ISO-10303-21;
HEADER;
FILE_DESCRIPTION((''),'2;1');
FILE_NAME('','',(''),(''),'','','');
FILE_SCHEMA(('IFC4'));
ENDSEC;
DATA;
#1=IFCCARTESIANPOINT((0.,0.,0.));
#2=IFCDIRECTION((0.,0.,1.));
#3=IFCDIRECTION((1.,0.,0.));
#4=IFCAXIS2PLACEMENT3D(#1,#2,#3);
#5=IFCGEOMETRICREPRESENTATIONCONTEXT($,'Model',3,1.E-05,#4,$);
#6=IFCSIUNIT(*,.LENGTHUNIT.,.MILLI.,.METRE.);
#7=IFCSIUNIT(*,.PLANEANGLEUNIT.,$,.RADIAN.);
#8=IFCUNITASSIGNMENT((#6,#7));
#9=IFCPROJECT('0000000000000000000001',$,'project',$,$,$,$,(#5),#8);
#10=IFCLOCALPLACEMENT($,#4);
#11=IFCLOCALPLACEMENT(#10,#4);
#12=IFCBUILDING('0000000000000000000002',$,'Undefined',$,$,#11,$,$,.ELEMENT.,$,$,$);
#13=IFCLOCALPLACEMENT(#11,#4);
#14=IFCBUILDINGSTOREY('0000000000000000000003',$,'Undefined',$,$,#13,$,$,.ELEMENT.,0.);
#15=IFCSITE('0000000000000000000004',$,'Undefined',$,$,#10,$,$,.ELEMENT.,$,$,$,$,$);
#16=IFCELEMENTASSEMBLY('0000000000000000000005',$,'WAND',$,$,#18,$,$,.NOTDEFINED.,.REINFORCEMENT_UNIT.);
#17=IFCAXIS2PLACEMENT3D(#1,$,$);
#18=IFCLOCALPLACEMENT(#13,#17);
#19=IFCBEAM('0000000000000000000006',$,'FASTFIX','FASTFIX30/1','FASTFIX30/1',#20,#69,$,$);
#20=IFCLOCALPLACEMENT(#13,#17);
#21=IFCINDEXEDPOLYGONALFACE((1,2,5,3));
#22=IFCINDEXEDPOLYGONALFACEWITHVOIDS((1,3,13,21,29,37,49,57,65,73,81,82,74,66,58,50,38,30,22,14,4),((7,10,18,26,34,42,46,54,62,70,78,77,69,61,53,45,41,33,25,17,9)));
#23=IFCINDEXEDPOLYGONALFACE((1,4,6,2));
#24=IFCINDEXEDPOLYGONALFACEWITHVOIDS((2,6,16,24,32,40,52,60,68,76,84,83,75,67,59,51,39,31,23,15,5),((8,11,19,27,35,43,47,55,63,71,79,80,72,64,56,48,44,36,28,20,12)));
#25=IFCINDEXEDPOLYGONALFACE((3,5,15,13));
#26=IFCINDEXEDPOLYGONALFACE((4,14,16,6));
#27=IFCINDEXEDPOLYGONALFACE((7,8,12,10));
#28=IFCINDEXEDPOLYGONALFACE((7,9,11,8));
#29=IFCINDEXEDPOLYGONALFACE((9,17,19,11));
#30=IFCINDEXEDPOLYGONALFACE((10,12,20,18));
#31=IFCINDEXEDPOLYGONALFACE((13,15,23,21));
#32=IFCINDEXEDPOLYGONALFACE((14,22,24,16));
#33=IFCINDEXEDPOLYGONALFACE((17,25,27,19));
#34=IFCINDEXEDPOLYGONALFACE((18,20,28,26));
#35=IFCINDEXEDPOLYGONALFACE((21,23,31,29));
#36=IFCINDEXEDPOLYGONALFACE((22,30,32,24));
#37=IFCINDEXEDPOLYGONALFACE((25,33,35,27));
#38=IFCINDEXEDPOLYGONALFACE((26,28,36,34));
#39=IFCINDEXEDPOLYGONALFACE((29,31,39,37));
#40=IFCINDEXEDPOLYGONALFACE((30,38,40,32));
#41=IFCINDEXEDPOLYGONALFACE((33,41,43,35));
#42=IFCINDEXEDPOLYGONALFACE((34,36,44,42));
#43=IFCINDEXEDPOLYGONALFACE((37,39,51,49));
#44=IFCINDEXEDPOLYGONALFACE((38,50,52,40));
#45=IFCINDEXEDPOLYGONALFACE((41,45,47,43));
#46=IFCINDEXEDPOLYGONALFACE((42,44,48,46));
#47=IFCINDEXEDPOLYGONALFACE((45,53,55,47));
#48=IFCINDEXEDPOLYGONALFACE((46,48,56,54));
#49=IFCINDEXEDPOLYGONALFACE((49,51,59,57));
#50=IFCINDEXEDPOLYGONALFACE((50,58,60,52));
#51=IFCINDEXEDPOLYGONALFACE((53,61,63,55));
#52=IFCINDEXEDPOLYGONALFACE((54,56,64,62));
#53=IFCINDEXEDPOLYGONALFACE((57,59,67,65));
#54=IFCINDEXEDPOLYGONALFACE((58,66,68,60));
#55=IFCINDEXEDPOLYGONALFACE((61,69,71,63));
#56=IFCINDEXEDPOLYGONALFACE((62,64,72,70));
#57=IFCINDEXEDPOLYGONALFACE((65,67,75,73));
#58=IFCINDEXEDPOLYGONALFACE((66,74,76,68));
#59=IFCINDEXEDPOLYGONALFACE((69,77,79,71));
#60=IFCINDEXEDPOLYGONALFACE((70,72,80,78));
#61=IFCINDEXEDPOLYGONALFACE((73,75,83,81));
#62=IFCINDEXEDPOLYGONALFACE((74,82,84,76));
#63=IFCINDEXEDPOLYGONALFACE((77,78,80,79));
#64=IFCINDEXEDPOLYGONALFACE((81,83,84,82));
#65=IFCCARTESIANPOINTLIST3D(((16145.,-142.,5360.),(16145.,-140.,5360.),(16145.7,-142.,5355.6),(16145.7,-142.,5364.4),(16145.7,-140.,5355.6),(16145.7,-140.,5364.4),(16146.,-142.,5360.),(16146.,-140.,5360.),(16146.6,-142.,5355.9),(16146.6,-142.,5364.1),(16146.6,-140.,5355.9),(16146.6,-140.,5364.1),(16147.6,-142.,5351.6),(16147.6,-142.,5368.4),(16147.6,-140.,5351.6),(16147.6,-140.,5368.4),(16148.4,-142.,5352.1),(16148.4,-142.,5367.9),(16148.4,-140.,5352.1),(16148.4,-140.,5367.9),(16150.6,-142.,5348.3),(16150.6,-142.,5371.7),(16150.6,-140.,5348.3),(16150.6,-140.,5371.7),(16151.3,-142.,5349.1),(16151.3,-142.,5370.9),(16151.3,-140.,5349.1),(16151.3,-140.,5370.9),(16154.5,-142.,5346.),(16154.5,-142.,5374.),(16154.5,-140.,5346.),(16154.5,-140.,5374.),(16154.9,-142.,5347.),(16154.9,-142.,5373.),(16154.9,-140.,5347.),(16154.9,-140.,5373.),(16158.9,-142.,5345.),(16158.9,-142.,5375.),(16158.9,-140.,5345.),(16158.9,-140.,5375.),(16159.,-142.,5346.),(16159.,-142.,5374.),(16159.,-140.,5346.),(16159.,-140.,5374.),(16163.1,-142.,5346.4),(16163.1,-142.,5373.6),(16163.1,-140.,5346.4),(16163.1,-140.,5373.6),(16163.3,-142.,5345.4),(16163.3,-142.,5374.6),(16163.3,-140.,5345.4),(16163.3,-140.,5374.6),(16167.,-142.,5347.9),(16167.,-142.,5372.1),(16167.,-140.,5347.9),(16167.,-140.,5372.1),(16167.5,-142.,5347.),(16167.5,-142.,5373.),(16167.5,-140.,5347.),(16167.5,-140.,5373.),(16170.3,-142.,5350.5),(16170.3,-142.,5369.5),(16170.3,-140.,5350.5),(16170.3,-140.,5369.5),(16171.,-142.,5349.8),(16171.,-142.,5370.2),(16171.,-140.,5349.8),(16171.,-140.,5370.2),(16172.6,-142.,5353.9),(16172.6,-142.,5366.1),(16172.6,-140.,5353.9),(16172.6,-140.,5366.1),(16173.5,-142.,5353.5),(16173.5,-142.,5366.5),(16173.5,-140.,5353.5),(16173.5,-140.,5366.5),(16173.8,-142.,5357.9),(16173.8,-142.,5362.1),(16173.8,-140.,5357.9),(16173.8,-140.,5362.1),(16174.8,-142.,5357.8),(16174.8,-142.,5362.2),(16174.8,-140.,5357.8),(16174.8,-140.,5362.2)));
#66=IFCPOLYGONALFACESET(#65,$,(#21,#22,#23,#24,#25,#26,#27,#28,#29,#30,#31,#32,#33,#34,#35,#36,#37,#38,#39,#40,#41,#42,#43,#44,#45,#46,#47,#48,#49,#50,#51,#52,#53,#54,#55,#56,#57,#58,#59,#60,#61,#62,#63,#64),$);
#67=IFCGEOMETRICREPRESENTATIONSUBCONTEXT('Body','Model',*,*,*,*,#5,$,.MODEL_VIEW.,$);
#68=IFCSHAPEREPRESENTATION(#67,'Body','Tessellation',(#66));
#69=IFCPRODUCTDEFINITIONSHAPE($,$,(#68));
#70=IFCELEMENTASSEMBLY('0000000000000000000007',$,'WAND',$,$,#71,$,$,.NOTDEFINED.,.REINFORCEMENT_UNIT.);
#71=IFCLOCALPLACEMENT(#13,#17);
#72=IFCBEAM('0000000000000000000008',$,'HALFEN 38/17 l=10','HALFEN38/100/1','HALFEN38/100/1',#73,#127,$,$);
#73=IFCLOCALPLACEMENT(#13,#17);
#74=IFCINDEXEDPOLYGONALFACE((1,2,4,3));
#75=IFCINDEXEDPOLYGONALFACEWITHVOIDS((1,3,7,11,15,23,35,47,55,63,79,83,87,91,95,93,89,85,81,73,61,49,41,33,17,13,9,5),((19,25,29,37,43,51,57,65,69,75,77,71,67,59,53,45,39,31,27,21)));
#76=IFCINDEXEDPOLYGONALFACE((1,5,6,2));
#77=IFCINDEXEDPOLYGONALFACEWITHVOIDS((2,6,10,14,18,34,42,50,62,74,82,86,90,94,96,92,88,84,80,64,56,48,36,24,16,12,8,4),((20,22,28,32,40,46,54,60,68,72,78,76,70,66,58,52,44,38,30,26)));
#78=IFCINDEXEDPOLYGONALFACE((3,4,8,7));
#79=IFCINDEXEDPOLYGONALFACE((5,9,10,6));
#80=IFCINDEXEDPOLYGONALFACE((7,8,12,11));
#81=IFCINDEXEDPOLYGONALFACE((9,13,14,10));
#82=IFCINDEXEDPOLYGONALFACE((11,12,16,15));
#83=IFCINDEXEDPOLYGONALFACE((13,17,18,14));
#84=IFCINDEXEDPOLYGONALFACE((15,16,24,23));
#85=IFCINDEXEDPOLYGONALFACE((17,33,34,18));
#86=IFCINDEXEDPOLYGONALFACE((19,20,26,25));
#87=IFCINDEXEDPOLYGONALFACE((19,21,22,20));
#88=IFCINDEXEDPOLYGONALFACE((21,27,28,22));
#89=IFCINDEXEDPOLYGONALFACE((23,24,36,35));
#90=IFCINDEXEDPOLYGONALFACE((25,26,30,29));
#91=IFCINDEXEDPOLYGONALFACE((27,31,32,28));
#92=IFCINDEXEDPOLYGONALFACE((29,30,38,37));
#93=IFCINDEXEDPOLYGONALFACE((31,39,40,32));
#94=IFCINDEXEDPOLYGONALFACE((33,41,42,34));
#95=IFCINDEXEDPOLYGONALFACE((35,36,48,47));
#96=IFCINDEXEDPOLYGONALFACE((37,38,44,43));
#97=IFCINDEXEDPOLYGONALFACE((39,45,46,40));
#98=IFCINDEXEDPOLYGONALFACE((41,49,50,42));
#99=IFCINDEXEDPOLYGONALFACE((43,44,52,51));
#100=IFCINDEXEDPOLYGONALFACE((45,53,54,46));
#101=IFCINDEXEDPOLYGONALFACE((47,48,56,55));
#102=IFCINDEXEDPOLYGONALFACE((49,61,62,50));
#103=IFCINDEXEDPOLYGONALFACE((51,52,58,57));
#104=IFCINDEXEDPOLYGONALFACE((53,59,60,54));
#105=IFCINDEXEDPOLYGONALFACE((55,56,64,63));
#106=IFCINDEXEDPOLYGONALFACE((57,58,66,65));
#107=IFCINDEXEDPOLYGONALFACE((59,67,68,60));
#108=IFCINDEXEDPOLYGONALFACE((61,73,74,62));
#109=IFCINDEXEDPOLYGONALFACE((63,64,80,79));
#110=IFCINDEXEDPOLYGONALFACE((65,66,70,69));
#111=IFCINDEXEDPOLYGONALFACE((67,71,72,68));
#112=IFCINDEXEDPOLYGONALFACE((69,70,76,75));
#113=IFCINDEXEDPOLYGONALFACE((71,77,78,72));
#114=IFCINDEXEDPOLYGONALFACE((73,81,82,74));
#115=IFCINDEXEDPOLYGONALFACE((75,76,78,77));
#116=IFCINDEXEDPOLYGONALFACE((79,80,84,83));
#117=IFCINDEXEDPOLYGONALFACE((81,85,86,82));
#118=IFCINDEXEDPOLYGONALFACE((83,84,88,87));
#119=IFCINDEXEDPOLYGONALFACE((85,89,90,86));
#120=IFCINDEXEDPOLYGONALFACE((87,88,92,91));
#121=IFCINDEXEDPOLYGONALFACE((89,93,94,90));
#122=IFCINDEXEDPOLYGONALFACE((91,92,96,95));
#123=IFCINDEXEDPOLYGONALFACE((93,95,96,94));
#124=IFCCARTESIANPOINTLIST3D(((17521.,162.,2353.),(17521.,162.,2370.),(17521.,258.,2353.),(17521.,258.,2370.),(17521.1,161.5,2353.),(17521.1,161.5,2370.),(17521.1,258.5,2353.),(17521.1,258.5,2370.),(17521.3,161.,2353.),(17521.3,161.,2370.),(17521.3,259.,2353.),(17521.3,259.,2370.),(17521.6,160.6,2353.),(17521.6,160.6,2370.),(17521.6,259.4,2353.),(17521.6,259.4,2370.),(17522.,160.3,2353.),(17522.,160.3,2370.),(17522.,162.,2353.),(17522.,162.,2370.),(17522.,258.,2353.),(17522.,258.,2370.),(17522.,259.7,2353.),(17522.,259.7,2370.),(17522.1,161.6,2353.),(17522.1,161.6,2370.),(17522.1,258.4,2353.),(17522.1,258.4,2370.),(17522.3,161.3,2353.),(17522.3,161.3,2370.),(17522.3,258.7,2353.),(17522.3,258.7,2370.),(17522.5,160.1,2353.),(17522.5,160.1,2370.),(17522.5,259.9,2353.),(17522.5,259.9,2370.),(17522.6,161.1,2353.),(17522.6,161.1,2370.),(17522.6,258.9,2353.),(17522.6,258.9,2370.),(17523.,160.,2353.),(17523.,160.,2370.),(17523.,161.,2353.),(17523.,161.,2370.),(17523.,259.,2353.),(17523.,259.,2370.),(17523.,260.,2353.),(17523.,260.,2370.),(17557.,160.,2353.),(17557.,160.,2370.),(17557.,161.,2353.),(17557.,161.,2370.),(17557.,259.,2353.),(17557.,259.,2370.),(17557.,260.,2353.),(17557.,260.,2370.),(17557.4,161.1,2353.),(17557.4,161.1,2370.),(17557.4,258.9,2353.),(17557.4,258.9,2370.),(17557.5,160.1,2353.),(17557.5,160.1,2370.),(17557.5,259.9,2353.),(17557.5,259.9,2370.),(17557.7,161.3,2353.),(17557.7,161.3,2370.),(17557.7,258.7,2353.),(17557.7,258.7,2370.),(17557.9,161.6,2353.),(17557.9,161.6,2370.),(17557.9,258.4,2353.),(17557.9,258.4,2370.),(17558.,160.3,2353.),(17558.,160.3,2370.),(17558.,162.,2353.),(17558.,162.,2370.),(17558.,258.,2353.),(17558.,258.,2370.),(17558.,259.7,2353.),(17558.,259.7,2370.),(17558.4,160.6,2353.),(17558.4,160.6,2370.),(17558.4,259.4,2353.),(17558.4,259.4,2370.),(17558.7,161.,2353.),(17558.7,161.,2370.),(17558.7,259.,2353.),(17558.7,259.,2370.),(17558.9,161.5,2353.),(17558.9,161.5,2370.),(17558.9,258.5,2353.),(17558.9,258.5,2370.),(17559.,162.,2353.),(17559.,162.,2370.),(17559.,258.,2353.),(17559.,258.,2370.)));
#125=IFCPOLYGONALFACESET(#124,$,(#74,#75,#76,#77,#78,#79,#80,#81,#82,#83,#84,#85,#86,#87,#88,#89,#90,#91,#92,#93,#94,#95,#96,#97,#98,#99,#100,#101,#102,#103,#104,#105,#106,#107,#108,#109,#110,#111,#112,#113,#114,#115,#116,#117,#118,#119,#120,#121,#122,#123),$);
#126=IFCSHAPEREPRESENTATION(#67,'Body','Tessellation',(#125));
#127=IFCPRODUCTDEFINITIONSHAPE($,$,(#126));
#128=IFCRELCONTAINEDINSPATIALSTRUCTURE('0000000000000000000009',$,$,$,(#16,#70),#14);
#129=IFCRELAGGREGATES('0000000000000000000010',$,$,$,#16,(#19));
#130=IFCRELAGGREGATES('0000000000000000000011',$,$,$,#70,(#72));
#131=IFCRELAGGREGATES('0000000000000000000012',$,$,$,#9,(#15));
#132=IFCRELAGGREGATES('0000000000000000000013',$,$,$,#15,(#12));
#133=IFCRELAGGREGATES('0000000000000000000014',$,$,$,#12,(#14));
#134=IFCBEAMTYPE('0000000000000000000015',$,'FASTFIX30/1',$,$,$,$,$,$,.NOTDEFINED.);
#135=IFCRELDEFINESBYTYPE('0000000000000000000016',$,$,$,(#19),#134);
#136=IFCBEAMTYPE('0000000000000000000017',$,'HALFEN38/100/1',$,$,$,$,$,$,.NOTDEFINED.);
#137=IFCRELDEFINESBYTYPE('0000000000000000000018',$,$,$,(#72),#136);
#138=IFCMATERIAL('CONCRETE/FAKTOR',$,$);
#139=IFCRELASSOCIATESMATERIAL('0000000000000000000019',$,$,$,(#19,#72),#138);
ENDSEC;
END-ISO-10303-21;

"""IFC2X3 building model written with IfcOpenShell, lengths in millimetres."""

from ifc_helpers import new_model, si_unit, frame, frame_2d, origin_with_axes, place, context, subcontext, project, spatial, hollow_rectangle, hollow_circle, extrude, material, type_object, element, aggregate, save


model = new_model("IFC2X3")

# Units and contexts
model_context = context("Model", 3, precision=1e-05, world=origin_with_axes())
body_context = subcontext(model_context, "Body", "Model", "MODEL_VIEW")
ifc_project = project(units=[si_unit("LENGTHUNIT", "METRE", prefix="MILLI"), si_unit("PLANEANGLEUNIT", "RADIAN")], contexts=[model_context])

# Site, building, storey
site_placement = place(None, origin_with_axes())
site = spatial("IfcSite", under=ifc_project, at=site_placement, Name="Undefined", CompositionType="ELEMENT")
building_placement = place(site_placement, origin_with_axes())
building = spatial("IfcBuilding", under=site, at=building_placement, Name="Undefined", CompositionType="ELEMENT")
storey_placement = place(building_placement, origin_with_axes())
storey = spatial("IfcBuildingStorey", under=building, at=storey_placement, Name="Undefined", CompositionType="ELEMENT", Elevation=0.0)

# Shared definitions
ifc_material_1 = material(Name="CONCRETE/FAKTOR")

# Element assembly, beam
assembly_1_placement = place(storey_placement, origin_with_axes())
assembly_1 = element("IfcElementAssembly", 1, at=assembly_1_placement, inside=storey, Name="WAND", AssemblyPlace="NOTDEFINED", PredefinedType="REINFORCEMENT_UNIT")
beam_type_1 = type_object("IfcBeamType", Name="FASTFIX30/1", PredefinedType="NOTDEFINED")
beam_1_placement = place(assembly_1_placement, frame((16160.0, -140.0, 5360.0), z_axis=(0.0, 0.0, 1.0), x_axis=(0.0, -1.0, 0.0)))
beam_1 = element("IfcBeam", 2, at=beam_1_placement, type_object=beam_type_1, material=ifc_material_1, Name="FASTFIX", Description="FASTFIX30/1", ObjectType="FASTFIX30/1", context=body_context, shape_type="SweptSolid", body=[
    extrude(hollow_circle(Radius=15.0, WallThickness=1.0, at=frame_2d((0.0, 0.0), x_axis=(1.0, 0.0))), frame((2.0, 0.0, 0.0), z_axis=(-1.0, 0.0, 0.0), x_axis=(0.0, -1.0, 0.0)), (0.0, 0.0, 1.0), 2.0),
])
aggregate(assembly_1, [beam_1])

# Element assembly, beam
assembly_2_placement = place(storey_placement, origin_with_axes())
assembly_2 = element("IfcElementAssembly", 3, at=assembly_2_placement, inside=storey, Name="WAND", AssemblyPlace="NOTDEFINED", PredefinedType="REINFORCEMENT_UNIT")
beam_type_2 = type_object("IfcBeamType", Name="HALFEN38/100/1", PredefinedType="NOTDEFINED")
beam_2_placement = place(assembly_2_placement, frame((17540.0, 210.0, 2370.0), z_axis=(-1.0, 0.0, 0.0), x_axis=(0.0, 0.0, -1.0)))
beam_2 = element("IfcBeam", 4, at=beam_2_placement, type_object=beam_type_2, material=ifc_material_1, Name="HALFEN 38/17 l=10", Description="HALFEN38/100/1", ObjectType="HALFEN38/100/1", context=body_context, shape_type="SweptSolid", body=[
    extrude(hollow_rectangle(XDim=100.0, YDim=38.0, WallThickness=1.0, InnerFilletRadius=1.0, OuterFilletRadius=2.0, at=frame_2d((0.0, 0.0), x_axis=(1.0, 0.0))), frame((17.0, 0.0, 0.0), z_axis=(-1.0, 0.0, 0.0), x_axis=(0.0, -1.0, 0.0)), (0.0, 0.0, 1.0), 17.0),
])
aggregate(assembly_2, [beam_2])

save(model, "model.ifc")
